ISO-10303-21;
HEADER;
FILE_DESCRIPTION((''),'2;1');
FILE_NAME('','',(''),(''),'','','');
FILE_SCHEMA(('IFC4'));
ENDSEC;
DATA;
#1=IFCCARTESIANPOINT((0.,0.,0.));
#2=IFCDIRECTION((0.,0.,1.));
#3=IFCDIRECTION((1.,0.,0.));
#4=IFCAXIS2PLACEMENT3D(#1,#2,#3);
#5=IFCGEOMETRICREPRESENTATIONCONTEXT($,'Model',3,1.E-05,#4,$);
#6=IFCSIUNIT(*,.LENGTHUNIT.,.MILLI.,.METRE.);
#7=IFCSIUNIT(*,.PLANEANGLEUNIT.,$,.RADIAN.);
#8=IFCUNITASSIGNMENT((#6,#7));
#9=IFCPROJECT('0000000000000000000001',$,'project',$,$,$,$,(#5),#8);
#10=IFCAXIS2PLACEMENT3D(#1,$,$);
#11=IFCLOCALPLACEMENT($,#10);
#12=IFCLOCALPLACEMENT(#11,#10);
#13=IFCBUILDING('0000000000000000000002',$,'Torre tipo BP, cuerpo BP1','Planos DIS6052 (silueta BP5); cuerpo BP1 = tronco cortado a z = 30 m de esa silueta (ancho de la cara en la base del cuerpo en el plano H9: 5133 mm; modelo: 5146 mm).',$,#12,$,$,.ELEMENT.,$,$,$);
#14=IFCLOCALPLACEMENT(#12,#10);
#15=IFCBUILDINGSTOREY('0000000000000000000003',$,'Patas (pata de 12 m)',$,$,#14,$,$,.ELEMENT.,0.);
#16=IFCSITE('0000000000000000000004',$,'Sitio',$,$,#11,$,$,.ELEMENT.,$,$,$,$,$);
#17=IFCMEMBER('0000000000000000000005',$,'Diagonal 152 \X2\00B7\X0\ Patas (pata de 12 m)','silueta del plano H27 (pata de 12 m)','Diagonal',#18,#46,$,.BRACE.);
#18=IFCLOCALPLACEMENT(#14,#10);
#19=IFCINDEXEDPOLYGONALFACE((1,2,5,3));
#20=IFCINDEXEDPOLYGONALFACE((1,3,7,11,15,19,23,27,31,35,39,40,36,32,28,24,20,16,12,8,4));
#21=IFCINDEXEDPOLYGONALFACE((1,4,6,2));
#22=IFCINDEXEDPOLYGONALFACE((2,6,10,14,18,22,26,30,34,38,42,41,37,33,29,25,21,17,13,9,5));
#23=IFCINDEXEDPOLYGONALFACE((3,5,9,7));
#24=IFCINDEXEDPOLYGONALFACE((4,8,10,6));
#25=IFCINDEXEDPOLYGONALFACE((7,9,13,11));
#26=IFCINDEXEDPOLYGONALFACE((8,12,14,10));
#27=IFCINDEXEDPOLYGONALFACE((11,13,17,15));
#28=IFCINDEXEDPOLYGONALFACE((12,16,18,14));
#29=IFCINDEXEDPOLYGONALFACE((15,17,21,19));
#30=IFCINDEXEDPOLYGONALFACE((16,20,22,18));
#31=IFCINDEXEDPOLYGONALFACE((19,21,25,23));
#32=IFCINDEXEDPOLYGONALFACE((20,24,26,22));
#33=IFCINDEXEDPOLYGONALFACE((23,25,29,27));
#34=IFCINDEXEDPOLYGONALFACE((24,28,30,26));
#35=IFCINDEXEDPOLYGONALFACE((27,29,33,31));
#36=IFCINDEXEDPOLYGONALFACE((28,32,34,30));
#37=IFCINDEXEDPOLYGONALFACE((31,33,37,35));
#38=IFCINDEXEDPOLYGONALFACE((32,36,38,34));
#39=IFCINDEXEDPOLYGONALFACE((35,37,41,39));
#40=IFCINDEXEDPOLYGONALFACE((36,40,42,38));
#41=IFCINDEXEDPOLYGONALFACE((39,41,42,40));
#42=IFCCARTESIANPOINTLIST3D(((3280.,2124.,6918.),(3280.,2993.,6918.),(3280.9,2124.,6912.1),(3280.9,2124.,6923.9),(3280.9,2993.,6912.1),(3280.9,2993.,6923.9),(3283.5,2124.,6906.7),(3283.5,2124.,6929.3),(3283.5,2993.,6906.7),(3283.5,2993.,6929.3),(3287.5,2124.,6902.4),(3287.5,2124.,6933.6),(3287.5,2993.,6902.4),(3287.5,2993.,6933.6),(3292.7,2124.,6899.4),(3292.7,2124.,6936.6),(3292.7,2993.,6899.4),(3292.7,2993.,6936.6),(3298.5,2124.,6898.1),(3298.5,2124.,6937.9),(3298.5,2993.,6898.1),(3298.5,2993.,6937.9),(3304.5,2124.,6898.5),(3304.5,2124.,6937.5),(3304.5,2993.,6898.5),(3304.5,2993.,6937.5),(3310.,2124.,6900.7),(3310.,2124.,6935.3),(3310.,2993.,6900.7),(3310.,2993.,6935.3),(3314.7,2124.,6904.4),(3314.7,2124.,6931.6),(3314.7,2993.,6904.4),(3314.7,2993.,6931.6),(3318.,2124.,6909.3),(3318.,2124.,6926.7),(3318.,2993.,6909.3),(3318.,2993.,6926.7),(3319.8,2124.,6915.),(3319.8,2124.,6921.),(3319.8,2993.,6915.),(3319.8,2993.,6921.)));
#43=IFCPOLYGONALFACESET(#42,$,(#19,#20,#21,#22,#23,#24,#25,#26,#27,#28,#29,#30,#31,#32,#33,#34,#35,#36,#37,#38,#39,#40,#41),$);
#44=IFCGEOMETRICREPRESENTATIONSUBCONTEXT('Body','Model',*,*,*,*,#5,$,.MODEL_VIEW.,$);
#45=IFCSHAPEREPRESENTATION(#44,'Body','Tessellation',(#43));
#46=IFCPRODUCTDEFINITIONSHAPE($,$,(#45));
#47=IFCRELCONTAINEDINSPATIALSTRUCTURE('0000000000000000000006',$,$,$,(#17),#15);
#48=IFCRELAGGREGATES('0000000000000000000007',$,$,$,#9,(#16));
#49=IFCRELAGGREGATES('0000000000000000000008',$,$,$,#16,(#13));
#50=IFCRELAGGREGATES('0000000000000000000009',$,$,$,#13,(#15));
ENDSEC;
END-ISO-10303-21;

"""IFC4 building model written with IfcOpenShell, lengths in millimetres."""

from ifc_helpers import new_model, si_unit, frame, origin, origin_with_axes, place, context, subcontext, project, spatial, circle, extrude, element, save


model = new_model("IFC4")

# Units and contexts
model_context = context("Model", 3, precision=1e-05, world=origin_with_axes())
body_context = subcontext(model_context, "Body", "Model", "MODEL_VIEW")
ifc_project = project(units=[si_unit("LENGTHUNIT", "METRE", prefix="MILLI"), si_unit("PLANEANGLEUNIT", "RADIAN")], contexts=[model_context])

# Site, building, storey
site_placement = place(None, origin())
site = spatial("IfcSite", under=ifc_project, at=site_placement, Name="Sitio", CompositionType="ELEMENT")
building_placement = place(site_placement, origin())
building = spatial("IfcBuilding", under=site, at=building_placement, Name="Torre tipo BP, cuerpo BP1", Description="Planos DIS6052 (silueta BP5); cuerpo BP1 = tronco cortado a z = 30 m de esa silueta (ancho de la cara en la base del cuerpo en el plano H9: 5133 mm; modelo: 5146 mm).", CompositionType="ELEMENT")
storey_placement = place(building_placement, origin())
storey = spatial("IfcBuildingStorey", under=building, at=storey_placement, Name="Patas (pata de 12 m)", CompositionType="ELEMENT", Elevation=0.0)

# Member
member_1_placement = place(storey_placement, frame((3300.0, 2993.0, 6918.0), z_axis=(0.0, -1.0, 0.0), x_axis=(-1.0, 0.0, 0.0)))
element("IfcMember", 1, at=member_1_placement, inside=storey, Name="Diagonal 152 · Patas (pata de 12 m)", Description="silueta del plano H27 (pata de 12 m)", ObjectType="Diagonal", PredefinedType="BRACE", context=body_context, shape_type="SweptSolid", body=[
    extrude(circle(Radius=20.0), None, (0.0, 0.0, 1.0), 869.0),
])

save(model, "model.ifc")
